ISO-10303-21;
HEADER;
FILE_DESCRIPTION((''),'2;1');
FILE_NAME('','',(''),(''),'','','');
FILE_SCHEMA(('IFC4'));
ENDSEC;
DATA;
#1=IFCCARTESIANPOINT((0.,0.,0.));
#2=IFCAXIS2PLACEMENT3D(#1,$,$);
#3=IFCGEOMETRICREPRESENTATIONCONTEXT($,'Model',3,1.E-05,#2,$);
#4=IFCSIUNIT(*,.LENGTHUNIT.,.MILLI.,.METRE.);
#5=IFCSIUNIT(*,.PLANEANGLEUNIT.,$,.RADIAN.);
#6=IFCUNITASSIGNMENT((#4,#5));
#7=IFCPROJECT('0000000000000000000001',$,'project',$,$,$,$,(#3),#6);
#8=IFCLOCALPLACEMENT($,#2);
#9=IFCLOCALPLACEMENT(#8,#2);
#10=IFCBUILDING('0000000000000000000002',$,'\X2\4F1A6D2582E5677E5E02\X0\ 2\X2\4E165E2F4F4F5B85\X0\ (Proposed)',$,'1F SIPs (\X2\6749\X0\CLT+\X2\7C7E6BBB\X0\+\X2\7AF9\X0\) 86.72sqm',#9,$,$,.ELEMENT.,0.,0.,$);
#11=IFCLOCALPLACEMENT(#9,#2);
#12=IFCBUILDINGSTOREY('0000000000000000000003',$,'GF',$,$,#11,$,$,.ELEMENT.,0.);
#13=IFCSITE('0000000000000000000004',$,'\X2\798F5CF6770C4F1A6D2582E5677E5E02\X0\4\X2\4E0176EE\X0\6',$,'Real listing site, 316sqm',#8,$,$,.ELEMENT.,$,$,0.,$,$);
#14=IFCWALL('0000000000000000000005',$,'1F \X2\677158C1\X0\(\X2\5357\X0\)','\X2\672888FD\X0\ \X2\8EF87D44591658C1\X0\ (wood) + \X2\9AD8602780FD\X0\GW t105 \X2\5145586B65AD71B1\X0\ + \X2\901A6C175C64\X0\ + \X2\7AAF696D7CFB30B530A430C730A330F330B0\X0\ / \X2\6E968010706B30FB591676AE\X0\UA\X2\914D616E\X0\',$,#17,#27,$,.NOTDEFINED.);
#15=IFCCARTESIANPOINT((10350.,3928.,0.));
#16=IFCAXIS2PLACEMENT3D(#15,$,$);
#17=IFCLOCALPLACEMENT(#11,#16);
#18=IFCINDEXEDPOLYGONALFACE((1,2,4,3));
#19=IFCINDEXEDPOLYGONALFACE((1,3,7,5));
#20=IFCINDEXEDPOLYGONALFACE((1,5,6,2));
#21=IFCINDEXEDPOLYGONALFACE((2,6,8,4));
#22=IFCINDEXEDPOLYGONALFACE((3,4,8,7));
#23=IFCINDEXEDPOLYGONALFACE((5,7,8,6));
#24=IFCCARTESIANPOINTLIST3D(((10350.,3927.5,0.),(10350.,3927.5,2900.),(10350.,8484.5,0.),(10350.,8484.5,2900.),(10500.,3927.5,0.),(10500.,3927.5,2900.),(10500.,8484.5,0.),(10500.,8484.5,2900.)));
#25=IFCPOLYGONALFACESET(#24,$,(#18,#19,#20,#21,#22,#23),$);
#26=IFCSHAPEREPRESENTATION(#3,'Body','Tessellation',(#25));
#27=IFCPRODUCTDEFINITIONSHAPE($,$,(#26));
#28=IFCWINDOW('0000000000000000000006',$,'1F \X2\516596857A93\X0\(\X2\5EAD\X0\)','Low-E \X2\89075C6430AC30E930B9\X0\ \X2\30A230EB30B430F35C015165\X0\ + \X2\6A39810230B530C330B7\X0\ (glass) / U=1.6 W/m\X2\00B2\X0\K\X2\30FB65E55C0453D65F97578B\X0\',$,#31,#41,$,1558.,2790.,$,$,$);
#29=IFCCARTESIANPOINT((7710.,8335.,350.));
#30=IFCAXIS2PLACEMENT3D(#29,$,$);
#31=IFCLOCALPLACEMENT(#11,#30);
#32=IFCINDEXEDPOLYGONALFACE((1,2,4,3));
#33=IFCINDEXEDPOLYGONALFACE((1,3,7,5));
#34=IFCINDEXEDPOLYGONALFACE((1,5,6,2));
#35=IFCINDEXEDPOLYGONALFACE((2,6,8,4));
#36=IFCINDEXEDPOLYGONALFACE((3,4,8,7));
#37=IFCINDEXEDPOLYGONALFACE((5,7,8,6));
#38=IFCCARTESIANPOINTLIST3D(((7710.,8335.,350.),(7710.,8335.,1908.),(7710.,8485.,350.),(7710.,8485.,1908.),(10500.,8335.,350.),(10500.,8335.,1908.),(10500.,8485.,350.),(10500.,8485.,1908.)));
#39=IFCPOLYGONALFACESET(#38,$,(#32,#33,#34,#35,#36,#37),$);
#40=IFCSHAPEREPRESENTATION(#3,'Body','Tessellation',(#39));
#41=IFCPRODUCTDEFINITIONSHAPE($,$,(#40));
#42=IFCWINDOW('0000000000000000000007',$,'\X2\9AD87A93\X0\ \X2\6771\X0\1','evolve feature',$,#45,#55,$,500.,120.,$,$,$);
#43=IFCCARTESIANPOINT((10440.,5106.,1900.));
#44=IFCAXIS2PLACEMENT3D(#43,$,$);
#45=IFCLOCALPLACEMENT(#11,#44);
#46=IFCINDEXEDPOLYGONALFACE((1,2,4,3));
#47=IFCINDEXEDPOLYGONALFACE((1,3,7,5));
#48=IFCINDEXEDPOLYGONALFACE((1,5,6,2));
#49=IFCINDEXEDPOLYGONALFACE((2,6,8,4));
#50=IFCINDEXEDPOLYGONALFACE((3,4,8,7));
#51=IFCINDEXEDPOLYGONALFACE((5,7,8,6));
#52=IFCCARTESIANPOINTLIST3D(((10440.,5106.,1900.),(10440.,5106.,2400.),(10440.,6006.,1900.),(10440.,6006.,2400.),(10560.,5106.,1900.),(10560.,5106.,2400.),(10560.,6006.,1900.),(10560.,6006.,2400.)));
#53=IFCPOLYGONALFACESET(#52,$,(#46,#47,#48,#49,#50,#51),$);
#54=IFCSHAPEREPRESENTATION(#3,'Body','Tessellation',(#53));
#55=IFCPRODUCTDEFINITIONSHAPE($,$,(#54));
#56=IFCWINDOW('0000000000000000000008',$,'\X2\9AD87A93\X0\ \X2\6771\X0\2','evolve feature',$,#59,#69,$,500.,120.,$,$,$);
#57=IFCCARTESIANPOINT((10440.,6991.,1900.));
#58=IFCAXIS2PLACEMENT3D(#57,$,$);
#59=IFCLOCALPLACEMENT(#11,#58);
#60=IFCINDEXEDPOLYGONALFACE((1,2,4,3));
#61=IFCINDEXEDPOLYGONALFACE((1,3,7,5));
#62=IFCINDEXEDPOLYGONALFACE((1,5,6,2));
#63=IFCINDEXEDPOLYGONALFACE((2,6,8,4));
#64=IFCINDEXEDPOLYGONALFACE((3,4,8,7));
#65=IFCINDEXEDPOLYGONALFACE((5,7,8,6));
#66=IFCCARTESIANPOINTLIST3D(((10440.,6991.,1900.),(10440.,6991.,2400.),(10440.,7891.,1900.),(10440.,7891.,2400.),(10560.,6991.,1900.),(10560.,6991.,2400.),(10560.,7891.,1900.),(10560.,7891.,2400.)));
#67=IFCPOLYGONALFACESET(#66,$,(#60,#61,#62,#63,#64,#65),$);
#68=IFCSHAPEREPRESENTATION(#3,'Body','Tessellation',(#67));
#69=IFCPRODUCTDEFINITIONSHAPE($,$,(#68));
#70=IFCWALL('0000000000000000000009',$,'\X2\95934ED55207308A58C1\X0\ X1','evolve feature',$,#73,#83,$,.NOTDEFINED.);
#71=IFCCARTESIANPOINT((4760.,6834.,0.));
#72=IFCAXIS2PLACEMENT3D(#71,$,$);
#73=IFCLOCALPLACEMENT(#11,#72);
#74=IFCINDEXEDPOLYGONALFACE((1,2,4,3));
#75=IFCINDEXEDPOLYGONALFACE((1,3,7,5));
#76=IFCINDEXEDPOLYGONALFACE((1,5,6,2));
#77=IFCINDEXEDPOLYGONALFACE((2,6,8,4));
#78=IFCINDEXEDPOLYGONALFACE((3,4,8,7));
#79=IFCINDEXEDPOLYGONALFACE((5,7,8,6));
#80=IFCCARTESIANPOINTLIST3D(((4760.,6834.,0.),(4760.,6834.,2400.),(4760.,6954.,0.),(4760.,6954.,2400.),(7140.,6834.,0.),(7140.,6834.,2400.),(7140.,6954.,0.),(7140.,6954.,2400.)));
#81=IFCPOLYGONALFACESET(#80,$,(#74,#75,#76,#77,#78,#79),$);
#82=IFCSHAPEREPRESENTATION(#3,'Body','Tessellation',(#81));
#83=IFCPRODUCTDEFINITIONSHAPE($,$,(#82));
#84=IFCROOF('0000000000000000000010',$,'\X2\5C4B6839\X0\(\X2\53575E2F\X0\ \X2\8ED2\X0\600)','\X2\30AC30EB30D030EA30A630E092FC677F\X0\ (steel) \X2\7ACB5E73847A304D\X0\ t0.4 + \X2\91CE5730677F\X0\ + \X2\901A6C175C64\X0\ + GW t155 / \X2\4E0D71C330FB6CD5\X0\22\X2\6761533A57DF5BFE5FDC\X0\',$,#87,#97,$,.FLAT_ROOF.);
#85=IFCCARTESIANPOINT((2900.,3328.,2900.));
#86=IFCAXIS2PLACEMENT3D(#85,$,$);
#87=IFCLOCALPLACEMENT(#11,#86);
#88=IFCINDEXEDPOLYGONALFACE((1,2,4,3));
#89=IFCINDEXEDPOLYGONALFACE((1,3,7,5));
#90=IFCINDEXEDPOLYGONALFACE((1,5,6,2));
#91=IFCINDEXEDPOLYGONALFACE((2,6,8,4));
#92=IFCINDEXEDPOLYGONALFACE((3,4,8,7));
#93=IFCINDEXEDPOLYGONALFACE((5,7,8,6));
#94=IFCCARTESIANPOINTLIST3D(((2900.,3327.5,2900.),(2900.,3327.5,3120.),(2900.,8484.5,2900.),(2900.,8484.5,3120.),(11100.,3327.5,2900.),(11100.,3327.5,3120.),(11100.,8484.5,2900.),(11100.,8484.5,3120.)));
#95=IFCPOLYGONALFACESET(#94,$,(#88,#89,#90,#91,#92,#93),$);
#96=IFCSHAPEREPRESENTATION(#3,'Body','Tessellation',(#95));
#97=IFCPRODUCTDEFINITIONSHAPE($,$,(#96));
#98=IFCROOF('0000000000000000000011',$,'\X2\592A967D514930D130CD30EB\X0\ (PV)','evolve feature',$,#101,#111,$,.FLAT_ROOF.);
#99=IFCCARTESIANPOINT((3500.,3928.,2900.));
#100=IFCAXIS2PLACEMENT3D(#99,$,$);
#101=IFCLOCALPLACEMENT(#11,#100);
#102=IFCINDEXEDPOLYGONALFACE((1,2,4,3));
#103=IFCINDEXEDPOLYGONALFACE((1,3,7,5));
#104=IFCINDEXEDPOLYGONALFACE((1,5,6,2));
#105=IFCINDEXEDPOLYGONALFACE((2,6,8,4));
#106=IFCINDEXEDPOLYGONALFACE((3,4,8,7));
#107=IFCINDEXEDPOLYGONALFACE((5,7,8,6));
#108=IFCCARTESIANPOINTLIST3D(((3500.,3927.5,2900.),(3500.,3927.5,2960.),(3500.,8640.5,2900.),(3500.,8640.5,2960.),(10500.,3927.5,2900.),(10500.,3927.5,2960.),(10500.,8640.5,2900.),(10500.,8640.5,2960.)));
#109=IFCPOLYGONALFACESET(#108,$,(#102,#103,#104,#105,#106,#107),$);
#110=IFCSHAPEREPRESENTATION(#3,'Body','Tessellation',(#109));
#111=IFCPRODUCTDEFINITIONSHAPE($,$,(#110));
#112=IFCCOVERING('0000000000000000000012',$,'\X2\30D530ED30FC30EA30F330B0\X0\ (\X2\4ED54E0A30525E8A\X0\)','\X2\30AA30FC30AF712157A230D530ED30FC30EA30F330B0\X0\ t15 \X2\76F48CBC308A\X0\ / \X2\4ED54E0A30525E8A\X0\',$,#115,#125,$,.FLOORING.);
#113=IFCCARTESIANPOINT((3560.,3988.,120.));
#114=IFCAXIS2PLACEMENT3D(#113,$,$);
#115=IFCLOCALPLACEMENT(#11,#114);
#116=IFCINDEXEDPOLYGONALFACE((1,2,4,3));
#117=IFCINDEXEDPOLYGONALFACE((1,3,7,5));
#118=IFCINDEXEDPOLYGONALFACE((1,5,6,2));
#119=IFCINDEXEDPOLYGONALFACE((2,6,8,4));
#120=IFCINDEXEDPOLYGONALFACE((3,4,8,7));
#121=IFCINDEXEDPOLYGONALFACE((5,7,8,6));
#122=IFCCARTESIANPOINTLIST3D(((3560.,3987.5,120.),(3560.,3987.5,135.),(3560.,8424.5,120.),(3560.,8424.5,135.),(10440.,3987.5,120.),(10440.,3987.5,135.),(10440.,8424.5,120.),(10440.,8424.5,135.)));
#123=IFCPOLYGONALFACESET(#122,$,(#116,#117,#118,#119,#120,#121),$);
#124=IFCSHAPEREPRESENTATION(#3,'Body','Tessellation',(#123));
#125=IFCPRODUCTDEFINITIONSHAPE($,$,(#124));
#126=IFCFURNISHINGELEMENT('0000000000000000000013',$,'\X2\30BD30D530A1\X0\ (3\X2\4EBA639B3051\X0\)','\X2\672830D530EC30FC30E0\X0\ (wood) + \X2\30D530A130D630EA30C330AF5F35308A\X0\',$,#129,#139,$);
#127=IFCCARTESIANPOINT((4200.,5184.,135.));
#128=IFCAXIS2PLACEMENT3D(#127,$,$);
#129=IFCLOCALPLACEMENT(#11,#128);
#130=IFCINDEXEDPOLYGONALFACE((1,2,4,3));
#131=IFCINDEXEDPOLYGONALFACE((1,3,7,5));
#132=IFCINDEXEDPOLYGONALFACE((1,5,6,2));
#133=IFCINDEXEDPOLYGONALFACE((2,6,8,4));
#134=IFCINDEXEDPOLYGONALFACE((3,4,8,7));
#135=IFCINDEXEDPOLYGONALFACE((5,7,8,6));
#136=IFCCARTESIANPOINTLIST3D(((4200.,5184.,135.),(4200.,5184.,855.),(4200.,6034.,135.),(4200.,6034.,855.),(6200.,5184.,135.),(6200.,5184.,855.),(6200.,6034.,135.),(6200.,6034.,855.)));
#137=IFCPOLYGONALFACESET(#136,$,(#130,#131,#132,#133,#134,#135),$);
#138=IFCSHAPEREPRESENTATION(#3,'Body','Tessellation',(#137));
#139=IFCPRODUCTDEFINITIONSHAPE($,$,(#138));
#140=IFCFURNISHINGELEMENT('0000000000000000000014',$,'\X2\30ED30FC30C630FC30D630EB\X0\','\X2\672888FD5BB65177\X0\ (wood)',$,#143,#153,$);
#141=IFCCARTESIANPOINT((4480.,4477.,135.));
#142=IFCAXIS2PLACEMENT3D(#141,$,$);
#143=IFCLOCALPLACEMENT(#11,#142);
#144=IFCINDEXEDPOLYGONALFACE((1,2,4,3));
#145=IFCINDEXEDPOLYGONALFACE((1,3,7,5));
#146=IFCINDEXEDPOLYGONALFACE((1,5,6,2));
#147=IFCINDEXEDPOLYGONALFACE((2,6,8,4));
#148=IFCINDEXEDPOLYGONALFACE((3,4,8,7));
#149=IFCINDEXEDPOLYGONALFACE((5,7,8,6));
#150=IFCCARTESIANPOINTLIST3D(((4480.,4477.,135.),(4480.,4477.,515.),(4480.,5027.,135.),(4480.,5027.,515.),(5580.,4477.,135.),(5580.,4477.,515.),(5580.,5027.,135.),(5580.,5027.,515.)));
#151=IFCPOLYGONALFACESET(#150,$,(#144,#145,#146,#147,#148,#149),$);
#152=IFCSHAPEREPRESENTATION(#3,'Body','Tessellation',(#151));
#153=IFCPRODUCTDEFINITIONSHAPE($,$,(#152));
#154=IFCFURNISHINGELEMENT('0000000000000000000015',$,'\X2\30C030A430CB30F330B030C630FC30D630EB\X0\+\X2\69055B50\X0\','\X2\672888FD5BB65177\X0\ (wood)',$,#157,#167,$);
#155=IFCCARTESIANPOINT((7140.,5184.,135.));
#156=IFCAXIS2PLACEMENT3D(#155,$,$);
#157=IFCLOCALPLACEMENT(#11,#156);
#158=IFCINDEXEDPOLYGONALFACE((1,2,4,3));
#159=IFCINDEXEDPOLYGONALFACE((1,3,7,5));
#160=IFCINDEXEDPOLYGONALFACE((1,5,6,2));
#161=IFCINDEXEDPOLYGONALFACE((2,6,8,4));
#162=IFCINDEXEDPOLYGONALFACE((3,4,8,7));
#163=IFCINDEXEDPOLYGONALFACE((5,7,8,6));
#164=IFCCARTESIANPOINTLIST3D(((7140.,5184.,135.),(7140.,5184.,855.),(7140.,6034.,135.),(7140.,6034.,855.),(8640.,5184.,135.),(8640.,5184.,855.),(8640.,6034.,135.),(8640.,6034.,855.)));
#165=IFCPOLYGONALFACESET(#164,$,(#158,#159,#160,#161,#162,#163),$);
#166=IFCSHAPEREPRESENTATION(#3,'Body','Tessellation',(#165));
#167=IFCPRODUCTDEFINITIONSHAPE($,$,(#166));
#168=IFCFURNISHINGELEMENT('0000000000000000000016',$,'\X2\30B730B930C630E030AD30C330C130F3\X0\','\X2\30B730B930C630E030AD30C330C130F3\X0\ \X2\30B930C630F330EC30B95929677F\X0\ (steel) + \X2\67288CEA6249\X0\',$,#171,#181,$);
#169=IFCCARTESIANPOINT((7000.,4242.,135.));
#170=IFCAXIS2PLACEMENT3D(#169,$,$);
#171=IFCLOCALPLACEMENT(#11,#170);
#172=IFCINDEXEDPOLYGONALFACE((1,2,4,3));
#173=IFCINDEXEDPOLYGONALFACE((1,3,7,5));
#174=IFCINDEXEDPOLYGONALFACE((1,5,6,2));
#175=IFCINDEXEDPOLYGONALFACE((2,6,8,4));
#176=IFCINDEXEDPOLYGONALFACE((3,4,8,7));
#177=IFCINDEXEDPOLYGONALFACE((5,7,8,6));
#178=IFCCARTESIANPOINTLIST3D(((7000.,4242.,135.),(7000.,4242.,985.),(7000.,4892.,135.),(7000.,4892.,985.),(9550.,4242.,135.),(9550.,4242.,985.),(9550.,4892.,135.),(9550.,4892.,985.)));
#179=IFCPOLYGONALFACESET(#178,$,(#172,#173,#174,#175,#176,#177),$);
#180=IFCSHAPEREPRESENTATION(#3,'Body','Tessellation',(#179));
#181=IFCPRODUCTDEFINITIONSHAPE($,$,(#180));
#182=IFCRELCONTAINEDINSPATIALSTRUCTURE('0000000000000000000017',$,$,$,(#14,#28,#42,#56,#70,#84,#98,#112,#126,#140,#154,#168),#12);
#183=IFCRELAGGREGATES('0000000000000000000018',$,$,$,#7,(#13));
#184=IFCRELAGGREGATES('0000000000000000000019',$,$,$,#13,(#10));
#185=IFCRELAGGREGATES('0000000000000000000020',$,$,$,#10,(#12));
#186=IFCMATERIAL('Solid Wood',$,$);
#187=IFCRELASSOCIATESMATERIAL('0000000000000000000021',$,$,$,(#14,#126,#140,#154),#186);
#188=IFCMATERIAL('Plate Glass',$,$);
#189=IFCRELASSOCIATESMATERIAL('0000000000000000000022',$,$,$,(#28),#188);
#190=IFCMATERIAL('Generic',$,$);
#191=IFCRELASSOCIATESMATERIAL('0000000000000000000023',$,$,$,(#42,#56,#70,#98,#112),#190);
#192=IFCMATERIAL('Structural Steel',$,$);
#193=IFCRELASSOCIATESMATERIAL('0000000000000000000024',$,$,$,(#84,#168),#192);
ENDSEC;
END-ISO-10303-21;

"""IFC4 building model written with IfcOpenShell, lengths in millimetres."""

from ifc_helpers import new_model, si_unit, frame, frame_2d, origin, place, context, project, spatial, rectangle, extrude, material, element, fill, save


model = new_model("IFC4")

# Units and contexts
model_context = context("Model", 3, precision=1e-05, world=origin())
ifc_project = project(units=[si_unit("LENGTHUNIT", "METRE", prefix="MILLI"), si_unit("PLANEANGLEUNIT", "RADIAN")], contexts=[model_context])

# Site, building, storey
site_placement = place(None, origin())
site = spatial("IfcSite", under=ifc_project, at=site_placement, Name="福島県会津若松市4丁目6", ObjectType="Real listing site, 316sqm", CompositionType="ELEMENT", RefElevation=0.0)
building_placement = place(site_placement, origin())
building = spatial("IfcBuilding", under=site, at=building_placement, Name="会津若松市 2世帯住宅 (Proposed)", ObjectType="1F SIPs (杉CLT+籾殻+竹) 86.72sqm", CompositionType="ELEMENT", ElevationOfRefHeight=0.0, ElevationOfTerrain=0.0)
storey_placement = place(building_placement, origin())
storey = spatial("IfcBuildingStorey", under=building, at=storey_placement, Name="GF", CompositionType="ELEMENT", Elevation=0.0)

# Shared definitions
ifc_material_1 = material(Name="Solid Wood")
ifc_material_2 = material(Name="Generic")

# Shared definitions
ifc_material_3 = material(Name="Plate Glass")

# Wall, openings, windows
wall_1_placement = place(storey_placement, frame((10350.0, 3928.0, 0.0)))
wall_1 = element("IfcWall", 1, at=wall_1_placement, inside=storey, material=ifc_material_1, Name="1F 東壁(南)", Description="木製 軸組外壁 (wood) + 高性能GW t105 充填断熱 + 通気層 + 窯業系サイディング / 準耐火・外皮UA配慮", PredefinedType="NOTDEFINED", context=model_context, shape_type="SweptSolid", body=[
    extrude(rectangle(XDim=150.0, YDim=4557.0, at=frame_2d((75.0, 2278.0))), frame((10350.0, 3928.0, 0.0)), (0.0, 0.0, 1.0), 2900.0),
])
opening_1_placement = place(storey_placement, frame((7710.0, 8335.0, 350.0)))
opening_1 = element("IfcOpeningElement", 2, at=opening_1_placement, cuts=wall_1, PredefinedType="NOTDEFINED", context=model_context, shape_type="SweptSolid", body=[
    extrude(rectangle(XDim=2790.0, YDim=150.0, at=frame_2d((1395.0, 75.0))), frame((7710.0, 8335.0, 350.0)), (0.0, 0.0, 1.0), 1558.0),
])
opening_2_placement = place(storey_placement, frame((10440.0, 5106.0, 1900.0)))
opening_2 = element("IfcOpeningElement", 3, at=opening_2_placement, cuts=wall_1, PredefinedType="NOTDEFINED", context=model_context, shape_type="SweptSolid", body=[
    extrude(rectangle(XDim=120.0, YDim=900.0, at=frame_2d((60.0, 450.0))), frame((10440.0, 5106.0, 1900.0)), (0.0, 0.0, 1.0), 500.0),
])
opening_3_placement = place(storey_placement, frame((10440.0, 6991.0, 1900.0)))
opening_3 = element("IfcOpeningElement", 4, at=opening_3_placement, cuts=wall_1, PredefinedType="NOTDEFINED", context=model_context, shape_type="SweptSolid", body=[
    extrude(rectangle(XDim=120.0, YDim=900.0, at=frame_2d((60.0, 450.0))), frame((10440.0, 6991.0, 1900.0)), (0.0, 0.0, 1.0), 500.0),
])
window_1_placement = place(storey_placement, frame((7710.0, 8335.0, 350.0)))
window_1 = element("IfcWindow", 5, at=window_1_placement, inside=storey, material=ifc_material_3, Name="1F 入隅窓(庭)", Description="Low-E 複層ガラス アルゴン封入 + 樹脂サッシ (glass) / U=1.6 W/m²K・日射取得型", OverallHeight=1558.0, OverallWidth=2790.0, context=model_context, shape_type="SweptSolid", body=[
    extrude(rectangle(XDim=2790.0, YDim=150.0, at=frame_2d((1395.0, 75.0))), frame((7710.0, 8335.0, 350.0)), (0.0, 0.0, 1.0), 1558.0),
])
fill(opening_1, window_1)
window_2_placement = place(storey_placement, frame((10440.0, 5106.0, 1900.0)))
window_2 = element("IfcWindow", 6, at=window_2_placement, inside=storey, material=ifc_material_2, Name="高窓 東1", Description="evolve feature", OverallHeight=500.0, OverallWidth=120.0, context=model_context, shape_type="SweptSolid", body=[
    extrude(rectangle(XDim=120.0, YDim=900.0, at=frame_2d((60.0, 450.0))), frame((10440.0, 5106.0, 1900.0)), (0.0, 0.0, 1.0), 500.0),
])
fill(opening_2, window_2)
window_3_placement = place(storey_placement, frame((10440.0, 6991.0, 1900.0)))
window_3 = element("IfcWindow", 7, at=window_3_placement, inside=storey, material=ifc_material_2, Name="高窓 東2", Description="evolve feature", OverallHeight=500.0, OverallWidth=120.0, context=model_context, shape_type="SweptSolid", body=[
    extrude(rectangle(XDim=120.0, YDim=900.0, at=frame_2d((60.0, 450.0))), frame((10440.0, 6991.0, 1900.0)), (0.0, 0.0, 1.0), 500.0),
])
fill(opening_3, window_3)

# Wall
wall_2_placement = place(storey_placement, frame((4760.0, 6834.0, 0.0)))
element("IfcWall", 8, at=wall_2_placement, inside=storey, material=ifc_material_2, Name="間仕切り壁 X1", Description="evolve feature", PredefinedType="NOTDEFINED", context=model_context, shape_type="SweptSolid", body=[
    extrude(rectangle(XDim=2380.0, YDim=120.0, at=frame_2d((1190.0, 60.0))), frame((4760.0, 6834.0, 0.0)), (0.0, 0.0, 1.0), 2400.0),
])

# Roofs
ifc_material_4 = material(Name="Structural Steel")
roof_1_placement = place(storey_placement, frame((2900.0, 3328.0, 2900.0)))
element("IfcRoof", 9, at=roof_1_placement, inside=storey, material=ifc_material_4, Name="屋根(南帯 軒600)", Description="ガルバリウム鋼板 (steel) 立平葺き t0.4 + 野地板 + 通気層 + GW t155 / 不燃・法22条区域対応", PredefinedType="FLAT_ROOF", context=model_context, shape_type="SweptSolid", body=[
    extrude(rectangle(XDim=8200.0, YDim=5157.0, at=frame_2d((4100.0, 2578.0))), frame((2900.0, 3328.0, 2900.0)), (0.0, 0.0, 1.0), 220.0),
])
roof_2_placement = place(storey_placement, frame((3500.0, 3928.0, 2900.0)))
element("IfcRoof", 10, at=roof_2_placement, inside=storey, material=ifc_material_2, Name="太陽光パネル (PV)", Description="evolve feature", PredefinedType="FLAT_ROOF", context=model_context, shape_type="SweptSolid", body=[
    extrude(rectangle(XDim=7000.0, YDim=4713.0, at=frame_2d((3500.0, 2356.0))), frame((3500.0, 3928.0, 2900.0)), (0.0, 0.0, 1.0), 60.0),
])

# Covering
covering_placement = place(storey_placement, frame((3560.0, 3988.0, 120.0)))
element("IfcCovering", 11, at=covering_placement, inside=storey, material=ifc_material_2, Name="フローリング (仕上げ床)", Description="オーク無垢フローリング t15 直貼り / 仕上げ床", PredefinedType="FLOORING", context=model_context, shape_type="SweptSolid", body=[
    extrude(rectangle(XDim=6880.0, YDim=4437.0, at=frame_2d((3440.0, 2218.0))), frame((3560.0, 3988.0, 120.0)), (0.0, 0.0, 1.0), 15.0),
])

# Furnishing elements
furnishing_1_placement = place(storey_placement, frame((4200.0, 5184.0, 135.0)))
element("IfcFurnishingElement", 12, at=furnishing_1_placement, inside=storey, material=ifc_material_1, Name="ソファ (3人掛け)", Description="木フレーム (wood) + ファブリック張り", context=model_context, shape_type="SweptSolid", body=[
    extrude(rectangle(XDim=2000.0, YDim=850.0, at=frame_2d((1000.0, 425.0))), frame((4200.0, 5184.0, 135.0)), (0.0, 0.0, 1.0), 720.0),
])
furnishing_2_placement = place(storey_placement, frame((4480.0, 4477.0, 135.0)))
element("IfcFurnishingElement", 13, at=furnishing_2_placement, inside=storey, material=ifc_material_1, Name="ローテーブル", Description="木製家具 (wood)", context=model_context, shape_type="SweptSolid", body=[
    extrude(rectangle(XDim=1100.0, YDim=550.0, at=frame_2d((550.0, 275.0))), frame((4480.0, 4477.0, 135.0)), (0.0, 0.0, 1.0), 380.0),
])
furnishing_3_placement = place(storey_placement, frame((7140.0, 5184.0, 135.0)))
element("IfcFurnishingElement", 14, at=furnishing_3_placement, inside=storey, material=ifc_material_1, Name="ダイニングテーブル+椅子", Description="木製家具 (wood)", context=model_context, shape_type="SweptSolid", body=[
    extrude(rectangle(XDim=1500.0, YDim=850.0, at=frame_2d((750.0, 425.0))), frame((7140.0, 5184.0, 135.0)), (0.0, 0.0, 1.0), 720.0),
])
furnishing_4_placement = place(storey_placement, frame((7000.0, 4242.0, 135.0)))
element("IfcFurnishingElement", 15, at=furnishing_4_placement, inside=storey, material=ifc_material_4, Name="システムキッチン", Description="システムキッチン ステンレス天板 (steel) + 木質扉", context=model_context, shape_type="SweptSolid", body=[
    extrude(rectangle(XDim=2550.0, YDim=650.0, at=frame_2d((1275.0, 325.0))), frame((7000.0, 4242.0, 135.0)), (0.0, 0.0, 1.0), 850.0),
])

save(model, "model.ifc")
